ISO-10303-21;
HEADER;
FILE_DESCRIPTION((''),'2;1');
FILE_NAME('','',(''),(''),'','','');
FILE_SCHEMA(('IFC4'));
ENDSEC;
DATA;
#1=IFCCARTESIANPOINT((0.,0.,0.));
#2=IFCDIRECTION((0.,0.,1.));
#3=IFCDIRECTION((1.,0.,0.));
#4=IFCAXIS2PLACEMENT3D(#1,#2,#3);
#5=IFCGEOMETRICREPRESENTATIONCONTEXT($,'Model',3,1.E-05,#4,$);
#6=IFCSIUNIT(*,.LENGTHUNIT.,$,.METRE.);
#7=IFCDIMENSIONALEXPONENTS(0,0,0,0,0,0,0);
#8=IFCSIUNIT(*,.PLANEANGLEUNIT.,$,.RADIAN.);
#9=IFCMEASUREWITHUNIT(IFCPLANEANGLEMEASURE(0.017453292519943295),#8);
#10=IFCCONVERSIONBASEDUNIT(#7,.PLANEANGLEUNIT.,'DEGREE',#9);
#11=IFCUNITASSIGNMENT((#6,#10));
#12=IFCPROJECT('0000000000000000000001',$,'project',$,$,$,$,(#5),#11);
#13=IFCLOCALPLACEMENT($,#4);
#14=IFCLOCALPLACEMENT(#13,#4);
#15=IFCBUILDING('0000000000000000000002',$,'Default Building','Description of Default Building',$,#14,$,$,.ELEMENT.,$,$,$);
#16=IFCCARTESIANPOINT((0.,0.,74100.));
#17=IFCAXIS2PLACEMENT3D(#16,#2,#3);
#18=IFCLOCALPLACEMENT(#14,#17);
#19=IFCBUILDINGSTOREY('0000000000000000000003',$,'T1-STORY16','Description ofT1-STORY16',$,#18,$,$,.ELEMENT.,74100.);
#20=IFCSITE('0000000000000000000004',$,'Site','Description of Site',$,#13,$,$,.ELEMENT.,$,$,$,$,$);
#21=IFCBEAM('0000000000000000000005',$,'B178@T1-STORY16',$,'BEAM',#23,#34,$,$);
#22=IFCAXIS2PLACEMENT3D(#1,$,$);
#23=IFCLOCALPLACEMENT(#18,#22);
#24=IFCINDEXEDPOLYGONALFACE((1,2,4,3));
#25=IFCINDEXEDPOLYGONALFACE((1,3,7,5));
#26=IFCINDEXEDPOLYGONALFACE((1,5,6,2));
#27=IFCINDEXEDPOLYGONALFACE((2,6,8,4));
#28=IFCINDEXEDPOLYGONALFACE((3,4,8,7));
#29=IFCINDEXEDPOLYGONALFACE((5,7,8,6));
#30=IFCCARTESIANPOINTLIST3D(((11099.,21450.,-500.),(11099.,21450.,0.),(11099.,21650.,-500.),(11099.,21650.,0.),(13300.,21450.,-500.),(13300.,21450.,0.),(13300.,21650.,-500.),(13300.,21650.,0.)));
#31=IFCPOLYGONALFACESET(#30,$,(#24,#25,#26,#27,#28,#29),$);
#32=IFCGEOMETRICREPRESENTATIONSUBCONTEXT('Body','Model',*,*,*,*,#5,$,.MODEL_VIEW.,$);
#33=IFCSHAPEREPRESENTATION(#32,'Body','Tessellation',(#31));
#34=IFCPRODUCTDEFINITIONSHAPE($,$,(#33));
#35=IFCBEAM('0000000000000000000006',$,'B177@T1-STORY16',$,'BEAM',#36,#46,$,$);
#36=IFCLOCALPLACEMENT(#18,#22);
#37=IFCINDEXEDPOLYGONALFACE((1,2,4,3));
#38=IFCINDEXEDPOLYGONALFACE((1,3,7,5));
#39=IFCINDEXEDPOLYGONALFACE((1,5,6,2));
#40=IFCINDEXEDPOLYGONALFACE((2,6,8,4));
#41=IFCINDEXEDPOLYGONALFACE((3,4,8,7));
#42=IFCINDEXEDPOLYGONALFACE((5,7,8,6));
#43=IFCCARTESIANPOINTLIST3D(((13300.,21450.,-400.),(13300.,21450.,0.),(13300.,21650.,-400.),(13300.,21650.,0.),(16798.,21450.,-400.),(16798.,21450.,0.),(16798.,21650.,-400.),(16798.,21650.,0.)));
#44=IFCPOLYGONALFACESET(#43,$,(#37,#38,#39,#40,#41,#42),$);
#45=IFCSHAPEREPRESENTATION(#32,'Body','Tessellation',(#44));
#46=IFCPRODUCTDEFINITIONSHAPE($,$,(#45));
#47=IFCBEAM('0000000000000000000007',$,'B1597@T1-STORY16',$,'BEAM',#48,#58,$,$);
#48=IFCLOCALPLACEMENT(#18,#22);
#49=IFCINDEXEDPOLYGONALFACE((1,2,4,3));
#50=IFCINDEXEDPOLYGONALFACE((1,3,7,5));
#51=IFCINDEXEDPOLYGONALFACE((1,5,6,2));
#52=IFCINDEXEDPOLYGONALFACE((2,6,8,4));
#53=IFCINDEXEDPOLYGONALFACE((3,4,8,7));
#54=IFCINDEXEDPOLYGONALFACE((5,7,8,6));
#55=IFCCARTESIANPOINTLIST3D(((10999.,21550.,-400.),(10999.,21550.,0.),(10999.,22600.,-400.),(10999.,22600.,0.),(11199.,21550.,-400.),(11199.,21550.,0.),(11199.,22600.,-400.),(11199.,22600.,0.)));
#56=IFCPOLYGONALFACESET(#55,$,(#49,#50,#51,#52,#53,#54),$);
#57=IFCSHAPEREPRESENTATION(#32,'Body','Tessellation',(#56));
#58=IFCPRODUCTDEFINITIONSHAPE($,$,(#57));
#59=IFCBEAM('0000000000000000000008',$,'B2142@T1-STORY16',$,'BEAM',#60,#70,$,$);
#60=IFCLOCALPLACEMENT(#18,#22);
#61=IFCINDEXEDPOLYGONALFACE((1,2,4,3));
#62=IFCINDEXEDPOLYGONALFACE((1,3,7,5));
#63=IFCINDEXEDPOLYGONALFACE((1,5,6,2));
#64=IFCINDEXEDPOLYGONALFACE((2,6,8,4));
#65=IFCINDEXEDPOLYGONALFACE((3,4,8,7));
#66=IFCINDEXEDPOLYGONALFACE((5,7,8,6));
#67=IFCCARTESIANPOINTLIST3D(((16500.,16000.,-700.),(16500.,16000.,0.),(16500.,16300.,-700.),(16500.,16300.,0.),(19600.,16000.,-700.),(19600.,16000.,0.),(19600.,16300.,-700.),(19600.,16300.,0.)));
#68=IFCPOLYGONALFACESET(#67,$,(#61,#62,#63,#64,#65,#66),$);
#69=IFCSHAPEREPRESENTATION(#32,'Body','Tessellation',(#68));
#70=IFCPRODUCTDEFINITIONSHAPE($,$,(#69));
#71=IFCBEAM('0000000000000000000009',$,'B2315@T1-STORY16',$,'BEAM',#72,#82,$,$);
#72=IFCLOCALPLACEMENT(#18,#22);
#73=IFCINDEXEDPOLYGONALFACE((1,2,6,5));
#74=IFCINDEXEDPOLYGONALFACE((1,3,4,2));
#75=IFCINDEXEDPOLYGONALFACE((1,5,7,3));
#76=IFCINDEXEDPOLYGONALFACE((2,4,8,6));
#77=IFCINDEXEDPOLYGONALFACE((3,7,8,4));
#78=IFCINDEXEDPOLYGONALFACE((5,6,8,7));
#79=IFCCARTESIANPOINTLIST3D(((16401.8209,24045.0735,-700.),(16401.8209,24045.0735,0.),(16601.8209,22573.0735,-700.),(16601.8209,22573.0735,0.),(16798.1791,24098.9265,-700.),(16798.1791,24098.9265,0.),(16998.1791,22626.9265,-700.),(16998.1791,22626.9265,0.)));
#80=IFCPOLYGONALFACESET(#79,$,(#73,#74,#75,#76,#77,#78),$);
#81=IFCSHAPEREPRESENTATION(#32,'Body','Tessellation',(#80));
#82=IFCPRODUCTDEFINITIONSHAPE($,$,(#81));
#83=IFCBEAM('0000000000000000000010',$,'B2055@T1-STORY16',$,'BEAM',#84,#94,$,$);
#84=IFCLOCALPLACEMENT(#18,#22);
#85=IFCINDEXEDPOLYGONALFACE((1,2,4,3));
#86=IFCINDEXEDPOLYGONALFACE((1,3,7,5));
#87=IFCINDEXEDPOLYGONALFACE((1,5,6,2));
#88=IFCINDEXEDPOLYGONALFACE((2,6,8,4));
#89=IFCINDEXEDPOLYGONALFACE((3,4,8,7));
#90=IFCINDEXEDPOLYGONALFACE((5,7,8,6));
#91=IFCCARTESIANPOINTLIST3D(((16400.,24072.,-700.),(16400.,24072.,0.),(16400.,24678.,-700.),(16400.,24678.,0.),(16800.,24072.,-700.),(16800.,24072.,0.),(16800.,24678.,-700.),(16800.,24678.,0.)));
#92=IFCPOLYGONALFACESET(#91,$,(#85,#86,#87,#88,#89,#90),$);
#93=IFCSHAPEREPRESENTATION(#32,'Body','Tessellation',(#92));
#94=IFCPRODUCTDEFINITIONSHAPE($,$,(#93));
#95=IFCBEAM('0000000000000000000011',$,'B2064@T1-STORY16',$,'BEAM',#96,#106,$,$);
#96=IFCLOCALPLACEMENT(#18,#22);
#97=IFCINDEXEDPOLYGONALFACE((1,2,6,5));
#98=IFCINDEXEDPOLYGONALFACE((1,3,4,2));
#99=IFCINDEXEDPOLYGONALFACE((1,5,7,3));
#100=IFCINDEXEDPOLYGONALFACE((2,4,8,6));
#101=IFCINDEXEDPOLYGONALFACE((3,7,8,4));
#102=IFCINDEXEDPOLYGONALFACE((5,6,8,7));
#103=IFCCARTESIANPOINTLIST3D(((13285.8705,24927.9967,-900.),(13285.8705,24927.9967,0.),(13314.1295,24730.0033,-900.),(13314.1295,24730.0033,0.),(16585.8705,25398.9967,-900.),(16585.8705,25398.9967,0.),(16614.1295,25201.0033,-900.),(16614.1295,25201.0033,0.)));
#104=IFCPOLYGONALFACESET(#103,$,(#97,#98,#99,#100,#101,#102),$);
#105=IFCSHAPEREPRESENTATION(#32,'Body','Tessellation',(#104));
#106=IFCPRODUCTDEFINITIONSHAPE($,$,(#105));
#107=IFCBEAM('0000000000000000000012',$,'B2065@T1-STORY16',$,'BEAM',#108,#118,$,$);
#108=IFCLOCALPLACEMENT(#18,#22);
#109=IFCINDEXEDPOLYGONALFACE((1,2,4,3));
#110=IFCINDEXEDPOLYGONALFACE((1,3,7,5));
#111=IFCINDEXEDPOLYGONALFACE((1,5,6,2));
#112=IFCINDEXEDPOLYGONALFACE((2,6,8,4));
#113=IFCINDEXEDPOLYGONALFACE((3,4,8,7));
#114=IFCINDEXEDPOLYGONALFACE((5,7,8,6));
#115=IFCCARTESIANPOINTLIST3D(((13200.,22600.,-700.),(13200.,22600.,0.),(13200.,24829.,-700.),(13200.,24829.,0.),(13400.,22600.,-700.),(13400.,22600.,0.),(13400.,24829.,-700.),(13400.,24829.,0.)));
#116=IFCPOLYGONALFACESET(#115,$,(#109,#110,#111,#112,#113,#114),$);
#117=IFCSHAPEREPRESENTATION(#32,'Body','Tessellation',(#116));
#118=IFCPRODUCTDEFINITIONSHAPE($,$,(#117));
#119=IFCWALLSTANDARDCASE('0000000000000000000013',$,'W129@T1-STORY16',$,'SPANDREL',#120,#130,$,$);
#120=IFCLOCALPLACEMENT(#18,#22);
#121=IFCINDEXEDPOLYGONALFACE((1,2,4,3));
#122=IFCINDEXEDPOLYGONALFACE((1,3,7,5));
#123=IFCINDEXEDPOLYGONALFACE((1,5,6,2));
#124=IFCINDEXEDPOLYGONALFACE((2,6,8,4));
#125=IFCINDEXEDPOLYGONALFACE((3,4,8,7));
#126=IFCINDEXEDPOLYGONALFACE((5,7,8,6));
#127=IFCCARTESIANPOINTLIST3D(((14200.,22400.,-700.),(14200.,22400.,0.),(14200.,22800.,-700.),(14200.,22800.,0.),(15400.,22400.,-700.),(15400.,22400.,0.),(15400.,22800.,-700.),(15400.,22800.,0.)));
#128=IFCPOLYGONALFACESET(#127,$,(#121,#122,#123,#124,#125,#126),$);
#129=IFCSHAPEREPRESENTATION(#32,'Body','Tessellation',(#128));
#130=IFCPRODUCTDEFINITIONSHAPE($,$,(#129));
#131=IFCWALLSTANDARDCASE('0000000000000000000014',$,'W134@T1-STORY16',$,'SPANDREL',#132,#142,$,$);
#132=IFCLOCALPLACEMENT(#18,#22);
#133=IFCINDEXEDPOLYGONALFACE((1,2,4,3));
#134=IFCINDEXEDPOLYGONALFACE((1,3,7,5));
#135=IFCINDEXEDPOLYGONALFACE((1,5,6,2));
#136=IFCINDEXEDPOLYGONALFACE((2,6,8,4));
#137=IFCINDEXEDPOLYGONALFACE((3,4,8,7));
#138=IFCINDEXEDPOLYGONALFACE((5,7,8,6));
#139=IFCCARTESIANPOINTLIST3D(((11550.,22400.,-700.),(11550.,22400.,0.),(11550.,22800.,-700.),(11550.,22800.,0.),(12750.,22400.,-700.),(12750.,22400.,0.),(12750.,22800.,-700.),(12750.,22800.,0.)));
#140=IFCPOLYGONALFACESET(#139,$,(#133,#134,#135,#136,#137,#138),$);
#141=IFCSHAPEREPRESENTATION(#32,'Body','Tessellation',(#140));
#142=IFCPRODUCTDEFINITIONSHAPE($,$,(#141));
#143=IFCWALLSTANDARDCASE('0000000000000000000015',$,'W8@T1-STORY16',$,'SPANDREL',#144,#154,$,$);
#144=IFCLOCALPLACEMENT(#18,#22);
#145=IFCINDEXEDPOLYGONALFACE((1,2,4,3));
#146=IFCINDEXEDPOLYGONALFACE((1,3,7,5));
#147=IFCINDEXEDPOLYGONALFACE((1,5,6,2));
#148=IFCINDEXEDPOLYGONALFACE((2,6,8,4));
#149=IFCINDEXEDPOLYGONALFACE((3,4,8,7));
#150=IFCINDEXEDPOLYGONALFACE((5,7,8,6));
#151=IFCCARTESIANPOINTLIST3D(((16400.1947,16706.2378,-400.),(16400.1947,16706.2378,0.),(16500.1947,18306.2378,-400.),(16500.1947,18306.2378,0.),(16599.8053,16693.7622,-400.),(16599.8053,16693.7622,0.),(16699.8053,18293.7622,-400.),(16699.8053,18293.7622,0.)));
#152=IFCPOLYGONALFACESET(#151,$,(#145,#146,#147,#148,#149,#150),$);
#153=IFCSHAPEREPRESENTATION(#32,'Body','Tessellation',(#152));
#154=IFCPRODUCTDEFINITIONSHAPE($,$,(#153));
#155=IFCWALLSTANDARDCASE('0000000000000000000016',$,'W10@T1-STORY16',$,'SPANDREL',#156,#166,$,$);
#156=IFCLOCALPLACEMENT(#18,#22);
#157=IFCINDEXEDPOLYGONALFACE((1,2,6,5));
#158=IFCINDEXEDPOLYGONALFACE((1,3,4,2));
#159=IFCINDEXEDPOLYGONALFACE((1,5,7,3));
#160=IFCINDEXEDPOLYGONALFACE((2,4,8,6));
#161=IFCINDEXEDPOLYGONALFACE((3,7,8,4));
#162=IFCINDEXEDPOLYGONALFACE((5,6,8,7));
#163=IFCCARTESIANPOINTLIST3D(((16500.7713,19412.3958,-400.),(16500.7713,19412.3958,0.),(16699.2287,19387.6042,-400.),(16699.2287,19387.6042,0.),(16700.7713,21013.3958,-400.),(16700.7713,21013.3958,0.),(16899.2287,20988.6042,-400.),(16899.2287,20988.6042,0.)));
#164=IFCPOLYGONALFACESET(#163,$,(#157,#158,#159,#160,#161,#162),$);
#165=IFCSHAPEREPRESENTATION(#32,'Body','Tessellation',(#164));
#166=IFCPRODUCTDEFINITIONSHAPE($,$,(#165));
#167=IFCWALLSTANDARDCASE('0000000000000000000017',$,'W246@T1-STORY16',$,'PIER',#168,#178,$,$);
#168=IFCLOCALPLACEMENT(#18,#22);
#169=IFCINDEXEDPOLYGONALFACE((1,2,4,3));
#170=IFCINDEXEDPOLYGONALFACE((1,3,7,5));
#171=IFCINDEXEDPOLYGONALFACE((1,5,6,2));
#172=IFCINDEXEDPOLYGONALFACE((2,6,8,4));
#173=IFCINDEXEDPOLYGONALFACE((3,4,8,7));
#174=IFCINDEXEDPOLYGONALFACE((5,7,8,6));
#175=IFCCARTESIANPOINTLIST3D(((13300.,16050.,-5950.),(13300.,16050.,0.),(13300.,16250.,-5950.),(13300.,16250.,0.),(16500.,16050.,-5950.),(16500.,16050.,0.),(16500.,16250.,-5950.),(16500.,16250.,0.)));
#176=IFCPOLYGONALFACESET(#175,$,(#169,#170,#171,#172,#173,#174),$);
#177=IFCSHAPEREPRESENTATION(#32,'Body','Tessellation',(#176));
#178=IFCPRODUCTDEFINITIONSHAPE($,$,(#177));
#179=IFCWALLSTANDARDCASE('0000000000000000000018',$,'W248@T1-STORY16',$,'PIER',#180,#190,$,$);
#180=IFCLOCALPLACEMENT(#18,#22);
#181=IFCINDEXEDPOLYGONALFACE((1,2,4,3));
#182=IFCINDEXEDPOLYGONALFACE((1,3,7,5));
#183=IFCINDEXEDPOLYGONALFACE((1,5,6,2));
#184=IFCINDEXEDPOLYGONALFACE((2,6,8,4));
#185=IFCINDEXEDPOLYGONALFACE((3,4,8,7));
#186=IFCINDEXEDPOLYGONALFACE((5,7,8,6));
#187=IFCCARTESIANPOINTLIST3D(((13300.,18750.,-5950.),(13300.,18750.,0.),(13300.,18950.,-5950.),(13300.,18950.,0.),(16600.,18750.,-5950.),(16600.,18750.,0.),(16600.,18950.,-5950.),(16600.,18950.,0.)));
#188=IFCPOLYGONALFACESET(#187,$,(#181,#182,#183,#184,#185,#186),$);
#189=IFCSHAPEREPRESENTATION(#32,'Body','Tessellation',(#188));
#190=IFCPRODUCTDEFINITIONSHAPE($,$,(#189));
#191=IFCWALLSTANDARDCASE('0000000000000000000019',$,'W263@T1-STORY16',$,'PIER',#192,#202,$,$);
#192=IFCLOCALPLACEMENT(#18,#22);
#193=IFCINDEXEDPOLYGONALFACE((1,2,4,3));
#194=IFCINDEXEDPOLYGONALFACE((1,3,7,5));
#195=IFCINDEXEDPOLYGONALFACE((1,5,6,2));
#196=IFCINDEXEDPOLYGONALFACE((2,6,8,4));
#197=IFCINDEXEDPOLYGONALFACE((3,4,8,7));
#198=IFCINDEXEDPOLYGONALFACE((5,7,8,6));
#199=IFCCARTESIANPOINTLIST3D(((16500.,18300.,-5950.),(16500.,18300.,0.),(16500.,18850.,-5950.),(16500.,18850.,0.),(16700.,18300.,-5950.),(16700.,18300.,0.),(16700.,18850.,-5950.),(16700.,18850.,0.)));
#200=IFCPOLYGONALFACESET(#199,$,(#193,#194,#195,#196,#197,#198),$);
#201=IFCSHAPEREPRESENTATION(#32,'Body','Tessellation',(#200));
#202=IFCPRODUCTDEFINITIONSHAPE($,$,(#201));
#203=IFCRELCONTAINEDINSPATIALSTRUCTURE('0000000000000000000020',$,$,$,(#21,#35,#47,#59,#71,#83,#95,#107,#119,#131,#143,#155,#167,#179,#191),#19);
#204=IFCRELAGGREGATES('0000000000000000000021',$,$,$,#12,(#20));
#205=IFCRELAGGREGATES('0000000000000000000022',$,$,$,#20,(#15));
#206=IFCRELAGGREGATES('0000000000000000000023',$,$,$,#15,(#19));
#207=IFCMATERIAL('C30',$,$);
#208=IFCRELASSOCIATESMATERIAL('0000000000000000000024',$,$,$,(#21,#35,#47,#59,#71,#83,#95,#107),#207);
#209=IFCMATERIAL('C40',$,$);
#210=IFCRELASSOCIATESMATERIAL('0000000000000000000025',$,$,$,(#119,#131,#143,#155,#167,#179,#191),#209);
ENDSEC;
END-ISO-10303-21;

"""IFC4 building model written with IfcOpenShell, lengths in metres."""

from ifc_helpers import new_model, entity, si_unit, converted_unit, frame, origin_with_axes, place, context, subcontext, project, spatial, indexed_curve, rectangle, outline, extrude, material, element, save


model = new_model("IFC4")

# Units and contexts
model_context = context("Model", 3, precision=1e-05, world=origin_with_axes())
body_context = subcontext(model_context, "Body", "Model", "MODEL_VIEW")
ifc_project = project(units=[si_unit("LENGTHUNIT", "METRE"), converted_unit("PLANEANGLEUNIT", "DEGREE", entity("IfcPlaneAngleMeasure", 0.017453292519943295), si_unit("PLANEANGLEUNIT", "RADIAN"), dimensions=[0, 0, 0, 0, 0, 0, 0])], contexts=[model_context])

# Site, building, storey
site_placement = place(None, origin_with_axes())
site = spatial("IfcSite", under=ifc_project, at=site_placement, Name="Site", Description="Description of Site", CompositionType="ELEMENT")
building_placement = place(site_placement, origin_with_axes())
building = spatial("IfcBuilding", under=site, at=building_placement, Name="Default Building", Description="Description of Default Building", CompositionType="ELEMENT")
storey_placement = place(building_placement, frame((0.0, 0.0, 74100.0), z_axis=(0.0, 0.0, 1.0), x_axis=(1.0, 0.0, 0.0)))
storey = spatial("IfcBuildingStorey", under=building, at=storey_placement, Name="T1-STORY16", Description="Description ofT1-STORY16", CompositionType="ELEMENT", Elevation=74100.0)

# Beams
ifc_material_1 = material(Name="C30")
beam_1_placement = place(storey_placement, frame((11099.0, 21550.0, -250.0), z_axis=(1.0, 0.0, 0.0), x_axis=(0.0, 1.0, 0.0)))
element("IfcBeam", 1, at=beam_1_placement, inside=storey, material=ifc_material_1, Name="B178@T1-STORY16", ObjectType="BEAM", context=body_context, shape_type="SweptSolid", body=[
    extrude(rectangle(XDim=200.0, YDim=500.0), origin_with_axes(), (0.0, 0.0, 1.0), 2201.0),
])
beam_2_placement = place(storey_placement, frame((13300.0, 21550.0, -200.0), z_axis=(1.0, 0.0, 0.0), x_axis=(0.0, 1.0, 0.0)))
element("IfcBeam", 2, at=beam_2_placement, inside=storey, material=ifc_material_1, Name="B177@T1-STORY16", ObjectType="BEAM", context=body_context, shape_type="SweptSolid", body=[
    extrude(rectangle(XDim=200.0, YDim=400.0), origin_with_axes(), (0.0, 0.0, 1.0), 3498.0),
])
beam_3_placement = place(storey_placement, frame((11099.0, 21550.0, -200.0), z_axis=(0.0, 1.0, 0.0), x_axis=(-1.0, 0.0, 0.0)))
element("IfcBeam", 3, at=beam_3_placement, inside=storey, material=ifc_material_1, Name="B1597@T1-STORY16", ObjectType="BEAM", context=body_context, shape_type="SweptSolid", body=[
    extrude(rectangle(XDim=200.0, YDim=400.0), origin_with_axes(), (0.0, 0.0, 1.0), 1050.0),
])
beam_4_placement = place(storey_placement, frame((16500.0, 16150.0, -350.0), z_axis=(1.0, 0.0, 0.0), x_axis=(0.0, 1.0, 0.0)))
element("IfcBeam", 4, at=beam_4_placement, inside=storey, material=ifc_material_1, Name="B2142@T1-STORY16", ObjectType="BEAM", context=body_context, shape_type="SweptSolid", body=[
    extrude(rectangle(XDim=300.0, YDim=700.0), origin_with_axes(), (0.0, 0.0, 1.0), 3100.0),
])
beam_5_placement = place(storey_placement, frame((16600.0, 24072.0, -350.0), z_axis=(0.134633, -0.990896, 0.0), x_axis=(0.990896, 0.134633, 0.0)))
element("IfcBeam", 5, at=beam_5_placement, inside=storey, material=ifc_material_1, Name="B2315@T1-STORY16", ObjectType="BEAM", context=body_context, shape_type="SweptSolid", body=[
    extrude(rectangle(XDim=400.0, YDim=700.0), origin_with_axes(), (0.0, 0.0, 1.0), 1485.5248),
])
beam_6_placement = place(storey_placement, frame((16600.0, 24072.0, -350.0), z_axis=(0.0, 1.0, 0.0), x_axis=(-1.0, 0.0, 0.0)))
element("IfcBeam", 6, at=beam_6_placement, inside=storey, material=ifc_material_1, Name="B2055@T1-STORY16", ObjectType="BEAM", context=body_context, shape_type="SweptSolid", body=[
    extrude(rectangle(XDim=400.0, YDim=700.0), origin_with_axes(), (0.0, 0.0, 1.0), 606.0),
])
beam_7_placement = place(storey_placement, frame((13300.0, 24829.0, -450.0), z_axis=(0.989967, 0.141295, 0.0), x_axis=(-0.141295, 0.989967, 0.0)))
element("IfcBeam", 7, at=beam_7_placement, inside=storey, material=ifc_material_1, Name="B2064@T1-STORY16", ObjectType="BEAM", context=body_context, shape_type="SweptSolid", body=[
    extrude(rectangle(XDim=200.0, YDim=900.0), origin_with_axes(), (0.0, 0.0, 1.0), 3333.4428),
])
beam_8_placement = place(storey_placement, frame((13300.0, 22600.0, -350.0), z_axis=(0.0, 1.0, 0.0), x_axis=(-1.0, 0.0, 0.0)))
element("IfcBeam", 8, at=beam_8_placement, inside=storey, material=ifc_material_1, Name="B2065@T1-STORY16", ObjectType="BEAM", context=body_context, shape_type="SweptSolid", body=[
    extrude(rectangle(XDim=200.0, YDim=700.0), origin_with_axes(), (0.0, 0.0, 1.0), 2229.0),
])

# Walls
ifc_material_2 = material(Name="C40")
for number, where, z_axis, x_axis, name in (
    (9, (14200.0, 22600.0, -700.0), (0.0, 0.0, 1.0), (1.0, 0.0, 0.0), "W129@T1-STORY16"),
    (10, (11550.0, 22600.0, -700.0), (0.0, 0.0, 1.0), (1.0, 0.0, 0.0), "W134@T1-STORY16"),
):
    element("IfcWallStandardCase", number, at=place(storey_placement, frame(where, z_axis=z_axis, x_axis=x_axis)), inside=storey, material=ifc_material_2, Name=name, ObjectType="SPANDREL", context=body_context, shape_type="SweptSolid", body=[
        extrude(outline(indexed_curve([(0.0, -200.0), (0.0, 200.0), (1200.0, 200.0), (1200.0, -200.0), (0.0, -200.0)], self_intersect=False)), origin_with_axes(), (0.0, 0.0, 1.0), 700.0),
    ])
wall_1_placement = place(storey_placement, frame((16500.0, 16700.0, -400.0), z_axis=(0.0, 0.0, 1.0), x_axis=(0.062378, 0.998053, 0.0)))
element("IfcWallStandardCase", 11, at=wall_1_placement, inside=storey, material=ifc_material_2, Name="W8@T1-STORY16", ObjectType="SPANDREL", context=body_context, shape_type="SweptSolid", body=[
    extrude(outline(indexed_curve([(0.0, -100.0), (0.0, 100.0), (1603.122, 100.0), (1603.122, -100.0), (0.0, -100.0)], self_intersect=False)), origin_with_axes(), (0.0, 0.0, 1.0), 400.0),
])
wall_2_placement = place(storey_placement, frame((16600.0, 19400.0, -400.0), z_axis=(0.0, 0.0, 1.0), x_axis=(0.123958, 0.992287, 0.0)))
element("IfcWallStandardCase", 12, at=wall_2_placement, inside=storey, material=ifc_material_2, Name="W10@T1-STORY16", ObjectType="SPANDREL", context=body_context, shape_type="SweptSolid", body=[
    extrude(outline(indexed_curve([(0.0, -100.0), (0.0, 100.0), (1613.4438, 100.0), (1613.4438, -100.0), (0.0, -100.0)], self_intersect=False)), origin_with_axes(), (0.0, 0.0, 1.0), 400.0),
])
wall_3_placement = place(storey_placement, frame((13300.0, 16150.0, -5950.0), z_axis=(0.0, 0.0, 1.0), x_axis=(1.0, 0.0, 0.0)))
element("IfcWallStandardCase", 13, at=wall_3_placement, inside=storey, material=ifc_material_2, Name="W246@T1-STORY16", ObjectType="PIER", context=body_context, shape_type="SweptSolid", body=[
    extrude(outline(indexed_curve([(0.0, -100.0), (0.0, 100.0), (3200.0, 100.0), (3200.0, -100.0), (0.0, -100.0)], self_intersect=False)), origin_with_axes(), (0.0, 0.0, 1.0), 5950.0),
])
wall_4_placement = place(storey_placement, frame((13300.0, 18850.0, -5950.0), z_axis=(0.0, 0.0, 1.0), x_axis=(1.0, 0.0, 0.0)))
element("IfcWallStandardCase", 14, at=wall_4_placement, inside=storey, material=ifc_material_2, Name="W248@T1-STORY16", ObjectType="PIER", context=body_context, shape_type="SweptSolid", body=[
    extrude(outline(indexed_curve([(0.0, -100.0), (0.0, 100.0), (3300.0, 100.0), (3300.0, -100.0), (0.0, -100.0)], self_intersect=False)), origin_with_axes(), (0.0, 0.0, 1.0), 5950.0),
])
for number, where, z_axis, x_axis, name in (
    (15, (16600.0, 18300.0, -5950.0), (0.0, 0.0, 1.0), (0.0, 1.0, 0.0), "W263@T1-STORY16"),
):
    element("IfcWallStandardCase", number, at=place(storey_placement, frame(where, z_axis=z_axis, x_axis=x_axis)), inside=storey, material=ifc_material_2, Name=name, ObjectType="PIER", context=body_context, shape_type="SweptSolid", body=[
        extrude(outline(indexed_curve([(0.0, -100.0), (0.0, 100.0), (550.0, 100.0), (550.0, -100.0), (0.0, -100.0)], self_intersect=False)), origin_with_axes(), (0.0, 0.0, 1.0), 5950.0),
    ])

save(model, "model.ifc")
